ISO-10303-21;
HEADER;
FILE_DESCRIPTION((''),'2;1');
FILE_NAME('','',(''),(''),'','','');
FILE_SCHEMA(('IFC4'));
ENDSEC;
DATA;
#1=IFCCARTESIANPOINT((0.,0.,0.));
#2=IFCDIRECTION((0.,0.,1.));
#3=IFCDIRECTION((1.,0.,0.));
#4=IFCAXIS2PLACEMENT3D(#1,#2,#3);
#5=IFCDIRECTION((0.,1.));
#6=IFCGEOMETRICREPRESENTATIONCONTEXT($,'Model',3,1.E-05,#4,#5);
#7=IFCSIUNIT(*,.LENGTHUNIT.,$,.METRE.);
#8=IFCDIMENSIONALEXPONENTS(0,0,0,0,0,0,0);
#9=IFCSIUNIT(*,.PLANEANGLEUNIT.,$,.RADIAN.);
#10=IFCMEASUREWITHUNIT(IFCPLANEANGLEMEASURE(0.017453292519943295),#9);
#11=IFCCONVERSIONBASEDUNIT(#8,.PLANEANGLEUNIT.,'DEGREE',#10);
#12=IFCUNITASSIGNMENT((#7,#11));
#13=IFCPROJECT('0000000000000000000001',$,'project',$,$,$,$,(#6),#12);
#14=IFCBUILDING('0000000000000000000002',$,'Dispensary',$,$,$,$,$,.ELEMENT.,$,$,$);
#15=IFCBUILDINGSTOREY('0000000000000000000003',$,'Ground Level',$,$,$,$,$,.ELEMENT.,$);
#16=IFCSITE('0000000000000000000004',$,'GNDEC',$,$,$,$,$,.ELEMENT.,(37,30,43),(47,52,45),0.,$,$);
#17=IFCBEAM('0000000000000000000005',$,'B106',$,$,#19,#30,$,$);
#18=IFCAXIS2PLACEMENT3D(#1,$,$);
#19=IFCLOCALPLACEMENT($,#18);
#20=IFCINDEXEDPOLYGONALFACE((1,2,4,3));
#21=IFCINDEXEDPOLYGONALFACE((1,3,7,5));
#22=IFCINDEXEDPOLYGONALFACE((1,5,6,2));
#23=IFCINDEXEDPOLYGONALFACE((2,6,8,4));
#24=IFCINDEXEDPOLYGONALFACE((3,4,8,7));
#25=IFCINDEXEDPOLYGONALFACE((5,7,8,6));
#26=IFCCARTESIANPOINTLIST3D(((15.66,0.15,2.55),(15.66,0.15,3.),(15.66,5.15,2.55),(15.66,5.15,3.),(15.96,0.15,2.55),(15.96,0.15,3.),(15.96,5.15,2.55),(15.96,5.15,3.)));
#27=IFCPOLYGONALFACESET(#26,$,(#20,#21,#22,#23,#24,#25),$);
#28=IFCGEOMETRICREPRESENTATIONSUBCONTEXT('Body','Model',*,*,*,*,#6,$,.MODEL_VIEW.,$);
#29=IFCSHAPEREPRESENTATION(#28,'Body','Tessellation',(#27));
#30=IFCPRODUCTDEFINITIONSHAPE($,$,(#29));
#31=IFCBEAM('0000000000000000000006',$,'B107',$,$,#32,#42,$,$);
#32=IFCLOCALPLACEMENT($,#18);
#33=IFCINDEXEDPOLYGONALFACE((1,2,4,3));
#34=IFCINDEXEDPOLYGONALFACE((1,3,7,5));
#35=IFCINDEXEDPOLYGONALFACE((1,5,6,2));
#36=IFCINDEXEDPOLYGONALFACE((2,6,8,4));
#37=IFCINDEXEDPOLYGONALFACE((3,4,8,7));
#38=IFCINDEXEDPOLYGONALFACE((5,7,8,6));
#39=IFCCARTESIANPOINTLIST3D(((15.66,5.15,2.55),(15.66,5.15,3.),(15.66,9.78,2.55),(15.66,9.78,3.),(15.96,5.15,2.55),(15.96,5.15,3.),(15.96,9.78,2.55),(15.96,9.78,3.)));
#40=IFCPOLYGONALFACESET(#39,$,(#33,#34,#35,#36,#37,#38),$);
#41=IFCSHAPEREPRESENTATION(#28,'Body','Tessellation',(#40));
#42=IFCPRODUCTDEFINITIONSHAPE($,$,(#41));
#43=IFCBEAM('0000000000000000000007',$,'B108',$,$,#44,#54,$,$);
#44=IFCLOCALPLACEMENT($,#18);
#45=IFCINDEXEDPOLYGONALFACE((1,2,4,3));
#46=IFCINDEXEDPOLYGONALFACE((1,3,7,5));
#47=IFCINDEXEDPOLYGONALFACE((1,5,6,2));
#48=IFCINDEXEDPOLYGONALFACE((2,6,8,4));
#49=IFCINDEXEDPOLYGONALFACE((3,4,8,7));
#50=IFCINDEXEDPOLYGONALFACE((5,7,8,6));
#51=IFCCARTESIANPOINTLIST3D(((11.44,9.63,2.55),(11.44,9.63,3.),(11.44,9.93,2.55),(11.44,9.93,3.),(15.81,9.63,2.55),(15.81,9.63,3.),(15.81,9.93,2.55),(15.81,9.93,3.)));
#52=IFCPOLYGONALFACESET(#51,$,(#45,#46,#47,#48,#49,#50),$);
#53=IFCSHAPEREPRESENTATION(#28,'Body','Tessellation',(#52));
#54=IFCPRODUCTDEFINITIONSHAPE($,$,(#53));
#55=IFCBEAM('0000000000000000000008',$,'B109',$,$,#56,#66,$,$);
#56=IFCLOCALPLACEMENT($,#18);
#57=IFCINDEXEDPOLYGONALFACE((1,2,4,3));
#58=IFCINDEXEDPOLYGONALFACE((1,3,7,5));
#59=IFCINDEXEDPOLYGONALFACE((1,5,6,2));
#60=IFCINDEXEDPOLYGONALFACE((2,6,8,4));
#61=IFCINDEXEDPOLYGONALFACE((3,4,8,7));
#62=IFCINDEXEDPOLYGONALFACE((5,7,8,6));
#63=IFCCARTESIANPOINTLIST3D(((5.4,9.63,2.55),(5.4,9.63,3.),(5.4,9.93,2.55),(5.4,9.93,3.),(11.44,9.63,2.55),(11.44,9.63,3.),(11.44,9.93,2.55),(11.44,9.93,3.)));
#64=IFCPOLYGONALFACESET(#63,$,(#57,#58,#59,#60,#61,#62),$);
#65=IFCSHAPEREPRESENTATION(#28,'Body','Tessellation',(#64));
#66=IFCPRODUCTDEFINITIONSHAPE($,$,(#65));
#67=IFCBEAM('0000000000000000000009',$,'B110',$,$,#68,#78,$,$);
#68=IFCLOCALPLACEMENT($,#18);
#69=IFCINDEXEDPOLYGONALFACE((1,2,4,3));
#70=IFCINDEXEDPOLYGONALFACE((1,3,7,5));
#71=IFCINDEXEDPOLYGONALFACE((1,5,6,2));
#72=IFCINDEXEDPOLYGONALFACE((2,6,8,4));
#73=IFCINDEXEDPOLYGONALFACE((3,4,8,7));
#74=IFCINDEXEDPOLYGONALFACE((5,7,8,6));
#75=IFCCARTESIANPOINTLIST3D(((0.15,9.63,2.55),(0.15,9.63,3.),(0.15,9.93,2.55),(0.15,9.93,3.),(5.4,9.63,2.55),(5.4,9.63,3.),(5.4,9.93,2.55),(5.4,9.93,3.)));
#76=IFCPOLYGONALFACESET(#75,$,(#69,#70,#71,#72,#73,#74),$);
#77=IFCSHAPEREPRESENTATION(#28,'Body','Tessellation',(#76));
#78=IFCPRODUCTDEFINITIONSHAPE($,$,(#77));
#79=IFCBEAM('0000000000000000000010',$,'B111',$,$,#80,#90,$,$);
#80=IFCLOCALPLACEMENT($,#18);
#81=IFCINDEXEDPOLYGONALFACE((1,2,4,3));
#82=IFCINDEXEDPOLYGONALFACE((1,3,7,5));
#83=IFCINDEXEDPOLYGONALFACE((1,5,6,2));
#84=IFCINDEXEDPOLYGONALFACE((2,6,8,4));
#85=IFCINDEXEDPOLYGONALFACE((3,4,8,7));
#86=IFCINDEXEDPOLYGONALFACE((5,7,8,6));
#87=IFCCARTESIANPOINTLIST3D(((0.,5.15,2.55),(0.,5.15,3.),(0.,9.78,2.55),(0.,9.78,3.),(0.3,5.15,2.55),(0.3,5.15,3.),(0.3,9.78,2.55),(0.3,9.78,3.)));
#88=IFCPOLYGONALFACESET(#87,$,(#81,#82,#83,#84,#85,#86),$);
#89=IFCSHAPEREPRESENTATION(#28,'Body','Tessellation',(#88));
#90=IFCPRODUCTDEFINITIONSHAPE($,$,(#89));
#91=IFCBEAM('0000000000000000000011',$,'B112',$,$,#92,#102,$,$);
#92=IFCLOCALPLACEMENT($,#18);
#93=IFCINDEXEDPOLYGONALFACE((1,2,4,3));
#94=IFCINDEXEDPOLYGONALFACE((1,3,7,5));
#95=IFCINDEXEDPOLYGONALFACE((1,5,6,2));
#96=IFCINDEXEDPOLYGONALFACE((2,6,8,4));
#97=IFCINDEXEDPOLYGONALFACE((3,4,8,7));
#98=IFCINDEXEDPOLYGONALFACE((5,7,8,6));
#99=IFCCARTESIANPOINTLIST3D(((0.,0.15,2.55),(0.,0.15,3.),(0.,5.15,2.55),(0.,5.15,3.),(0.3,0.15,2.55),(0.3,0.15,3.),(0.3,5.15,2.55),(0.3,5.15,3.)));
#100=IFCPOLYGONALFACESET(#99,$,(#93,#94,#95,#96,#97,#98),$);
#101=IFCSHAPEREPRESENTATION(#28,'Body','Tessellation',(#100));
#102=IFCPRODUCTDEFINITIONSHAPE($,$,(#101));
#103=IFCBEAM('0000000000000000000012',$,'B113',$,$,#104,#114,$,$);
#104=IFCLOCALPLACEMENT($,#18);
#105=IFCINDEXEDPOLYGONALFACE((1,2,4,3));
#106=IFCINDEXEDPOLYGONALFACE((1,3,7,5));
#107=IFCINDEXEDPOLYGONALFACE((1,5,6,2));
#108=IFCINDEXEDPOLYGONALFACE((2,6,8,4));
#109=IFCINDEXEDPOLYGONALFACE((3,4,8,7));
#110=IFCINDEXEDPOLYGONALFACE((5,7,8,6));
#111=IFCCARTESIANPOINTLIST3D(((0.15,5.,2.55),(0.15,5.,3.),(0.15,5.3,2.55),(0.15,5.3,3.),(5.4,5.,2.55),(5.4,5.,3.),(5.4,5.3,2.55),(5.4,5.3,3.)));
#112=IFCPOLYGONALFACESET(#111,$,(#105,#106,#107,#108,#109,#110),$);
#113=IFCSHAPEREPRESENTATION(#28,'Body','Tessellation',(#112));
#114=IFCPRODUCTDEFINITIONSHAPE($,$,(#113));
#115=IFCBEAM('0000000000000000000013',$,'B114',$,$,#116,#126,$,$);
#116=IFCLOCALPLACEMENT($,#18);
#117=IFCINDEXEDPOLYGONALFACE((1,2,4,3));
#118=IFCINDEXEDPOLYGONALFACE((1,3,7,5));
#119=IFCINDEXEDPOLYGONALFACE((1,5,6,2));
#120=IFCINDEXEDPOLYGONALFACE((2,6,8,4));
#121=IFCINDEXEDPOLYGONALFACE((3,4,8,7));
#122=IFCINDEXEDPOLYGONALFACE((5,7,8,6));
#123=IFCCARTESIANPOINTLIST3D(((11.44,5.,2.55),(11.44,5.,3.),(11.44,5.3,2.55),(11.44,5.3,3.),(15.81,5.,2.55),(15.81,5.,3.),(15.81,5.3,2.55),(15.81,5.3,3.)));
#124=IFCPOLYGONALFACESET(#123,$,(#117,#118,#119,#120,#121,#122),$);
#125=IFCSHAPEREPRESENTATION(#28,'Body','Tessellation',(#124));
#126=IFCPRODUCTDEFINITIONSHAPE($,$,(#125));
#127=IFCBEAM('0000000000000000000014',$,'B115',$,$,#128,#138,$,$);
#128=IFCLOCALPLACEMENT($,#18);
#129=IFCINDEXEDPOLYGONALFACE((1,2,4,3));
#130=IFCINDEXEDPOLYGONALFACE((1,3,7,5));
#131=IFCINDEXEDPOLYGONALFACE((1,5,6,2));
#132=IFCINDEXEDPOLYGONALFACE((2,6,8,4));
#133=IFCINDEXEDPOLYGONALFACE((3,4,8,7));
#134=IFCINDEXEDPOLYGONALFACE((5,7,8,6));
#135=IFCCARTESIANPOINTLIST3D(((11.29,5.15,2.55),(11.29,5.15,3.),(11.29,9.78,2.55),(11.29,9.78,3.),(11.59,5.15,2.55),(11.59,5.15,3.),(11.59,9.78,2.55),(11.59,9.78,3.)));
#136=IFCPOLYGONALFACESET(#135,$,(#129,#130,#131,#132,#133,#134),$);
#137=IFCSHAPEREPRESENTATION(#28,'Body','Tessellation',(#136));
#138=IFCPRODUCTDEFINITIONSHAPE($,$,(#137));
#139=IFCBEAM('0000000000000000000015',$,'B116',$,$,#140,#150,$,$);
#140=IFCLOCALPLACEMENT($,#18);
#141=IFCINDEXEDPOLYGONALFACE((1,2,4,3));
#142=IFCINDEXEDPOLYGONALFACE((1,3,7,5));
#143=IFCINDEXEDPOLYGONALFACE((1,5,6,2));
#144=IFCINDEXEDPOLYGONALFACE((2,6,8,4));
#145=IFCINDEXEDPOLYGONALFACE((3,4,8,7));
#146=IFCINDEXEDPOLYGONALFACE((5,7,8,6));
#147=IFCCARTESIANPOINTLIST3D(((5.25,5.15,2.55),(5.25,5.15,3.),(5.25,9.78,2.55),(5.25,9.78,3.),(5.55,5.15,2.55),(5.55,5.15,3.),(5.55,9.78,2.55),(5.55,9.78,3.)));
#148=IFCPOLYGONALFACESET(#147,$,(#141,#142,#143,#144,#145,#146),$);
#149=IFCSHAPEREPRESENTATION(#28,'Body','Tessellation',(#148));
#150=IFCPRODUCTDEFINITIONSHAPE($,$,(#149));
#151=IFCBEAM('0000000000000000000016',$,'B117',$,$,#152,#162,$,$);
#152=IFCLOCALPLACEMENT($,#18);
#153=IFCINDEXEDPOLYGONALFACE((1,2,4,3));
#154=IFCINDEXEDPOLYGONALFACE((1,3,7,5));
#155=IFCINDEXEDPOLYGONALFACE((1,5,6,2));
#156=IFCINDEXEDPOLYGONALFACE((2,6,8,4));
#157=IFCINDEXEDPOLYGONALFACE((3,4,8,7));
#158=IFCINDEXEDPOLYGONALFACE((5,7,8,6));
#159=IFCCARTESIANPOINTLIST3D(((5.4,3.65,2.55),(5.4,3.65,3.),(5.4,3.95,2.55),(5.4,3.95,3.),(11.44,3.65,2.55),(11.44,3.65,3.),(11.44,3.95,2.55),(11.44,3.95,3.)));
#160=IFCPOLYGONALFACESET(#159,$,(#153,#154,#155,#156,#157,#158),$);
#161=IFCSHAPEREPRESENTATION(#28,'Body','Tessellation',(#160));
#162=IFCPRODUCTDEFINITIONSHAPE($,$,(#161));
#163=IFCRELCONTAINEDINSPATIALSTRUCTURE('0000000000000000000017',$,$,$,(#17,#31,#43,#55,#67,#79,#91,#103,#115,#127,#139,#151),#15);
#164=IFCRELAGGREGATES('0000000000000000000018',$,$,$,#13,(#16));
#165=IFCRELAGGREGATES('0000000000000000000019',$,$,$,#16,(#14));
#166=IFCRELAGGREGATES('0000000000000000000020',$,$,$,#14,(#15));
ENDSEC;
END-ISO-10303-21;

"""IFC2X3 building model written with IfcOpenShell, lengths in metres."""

from ifc_helpers import new_model, entity, si_unit, converted_unit, direction, frame, frame_2d, origin_with_axes, place, context, subcontext, project, spatial, rectangle, extrude, element, save


model = new_model("IFC2X3")

# Units and contexts
model_context = context("Model", 3, precision=1e-05, world=origin_with_axes(), true_north=direction((0.0, 1.0)))
body_context = subcontext(model_context, "Body", "Model", "MODEL_VIEW")
ifc_project = project(units=[si_unit("LENGTHUNIT", "METRE"), converted_unit("PLANEANGLEUNIT", "DEGREE", entity("IfcPlaneAngleMeasure", 0.017453292519943295), si_unit("PLANEANGLEUNIT", "RADIAN"), dimensions=[0, 0, 0, 0, 0, 0, 0])], contexts=[model_context])

# Site, building, storey
site = spatial("IfcSite", under=ifc_project, Name="GNDEC", CompositionType="ELEMENT", RefLatitude=(37, 30, 43), RefLongitude=(47, 52, 45), RefElevation=0.0)
building = spatial("IfcBuilding", under=site, Name="Dispensary", CompositionType="ELEMENT")
storey = spatial("IfcBuildingStorey", under=building, Name="Ground Level", CompositionType="ELEMENT")

# Shared definitions
placement = place(None, origin_with_axes())

# Beams
element("IfcBeam", 1, at=placement, inside=storey, Name="B106", context=body_context, shape_type="SweptSolid", body=[
    extrude(rectangle(XDim=0.3, YDim=0.45, at=frame_2d((0.0, 0.0), x_axis=(0.0, 1.0))), frame((15.81, 0.15, 2.775), z_axis=(0.0, 1.0, 0.0), x_axis=(0.0, 0.0, -1.0)), (0.0, 0.0, 1.0), 5.0),
])
element("IfcBeam", 2, at=placement, inside=storey, Name="B107", context=body_context, shape_type="SweptSolid", body=[
    extrude(rectangle(XDim=0.3, YDim=0.45, at=frame_2d((0.0, 0.0), x_axis=(0.0, 1.0))), frame((15.81, 5.15, 2.775), z_axis=(0.0, 1.0, 0.0), x_axis=(0.0, 0.0, -1.0)), (0.0, 0.0, 1.0), 4.63),
])
element("IfcBeam", 3, at=placement, inside=storey, Name="B108", context=body_context, shape_type="SweptSolid", body=[
    extrude(rectangle(XDim=0.3, YDim=0.45, at=frame_2d((0.0, 0.0), x_axis=(0.0, 1.0))), frame((15.81, 9.78, 2.775), z_axis=(-1.0, 0.0, 0.0), x_axis=(0.0, 0.0, -1.0)), (0.0, 0.0, 1.0), 4.37),
])
element("IfcBeam", 4, at=placement, inside=storey, Name="B109", context=body_context, shape_type="SweptSolid", body=[
    extrude(rectangle(XDim=0.3, YDim=0.45, at=frame_2d((0.0, 0.0), x_axis=(0.0, 1.0))), frame((11.44, 9.78, 2.775), z_axis=(-1.0, 0.0, 0.0), x_axis=(0.0, 0.0, -1.0)), (0.0, 0.0, 1.0), 6.04),
])
element("IfcBeam", 5, at=placement, inside=storey, Name="B110", context=body_context, shape_type="SweptSolid", body=[
    extrude(rectangle(XDim=0.3, YDim=0.45, at=frame_2d((0.0, 0.0), x_axis=(0.0, 1.0))), frame((5.4, 9.78, 2.775), z_axis=(-1.0, 0.0, 0.0), x_axis=(0.0, 0.0, -1.0)), (0.0, 0.0, 1.0), 5.25),
])
element("IfcBeam", 6, at=placement, inside=storey, Name="B111", context=body_context, shape_type="SweptSolid", body=[
    extrude(rectangle(XDim=0.3, YDim=0.45, at=frame_2d((0.0, 0.0), x_axis=(0.0, 1.0))), frame((0.15, 9.78, 2.775), z_axis=(0.0, -1.0, 0.0), x_axis=(0.0, 0.0, -1.0)), (0.0, 0.0, 1.0), 4.63),
])
element("IfcBeam", 7, at=placement, inside=storey, Name="B112", context=body_context, shape_type="SweptSolid", body=[
    extrude(rectangle(XDim=0.3, YDim=0.45, at=frame_2d((0.0, 0.0), x_axis=(0.0, 1.0))), frame((0.15, 5.15, 2.775), z_axis=(0.0, -1.0, 0.0), x_axis=(0.0, 0.0, -1.0)), (0.0, 0.0, 1.0), 5.0),
])
element("IfcBeam", 8, at=placement, inside=storey, Name="B113", context=body_context, shape_type="SweptSolid", body=[
    extrude(rectangle(XDim=0.3, YDim=0.45, at=frame_2d((0.0, 0.0), x_axis=(0.0, 1.0))), frame((0.15, 5.15, 2.775), z_axis=(1.0, 0.0, 0.0), x_axis=(0.0, 0.0, -1.0)), (0.0, 0.0, 1.0), 5.25),
])
element("IfcBeam", 9, at=placement, inside=storey, Name="B114", context=body_context, shape_type="SweptSolid", body=[
    extrude(rectangle(XDim=0.3, YDim=0.45, at=frame_2d((0.0, 0.0), x_axis=(0.0, 1.0))), frame((15.81, 5.15, 2.775), z_axis=(-1.0, 0.0, 0.0), x_axis=(0.0, 0.0, -1.0)), (0.0, 0.0, 1.0), 4.37),
])
element("IfcBeam", 10, at=placement, inside=storey, Name="B115", context=body_context, shape_type="SweptSolid", body=[
    extrude(rectangle(XDim=0.3, YDim=0.45, at=frame_2d((0.0, 0.0), x_axis=(0.0, 1.0))), frame((11.44, 5.15, 2.775), z_axis=(0.0, 1.0, 0.0), x_axis=(0.0, 0.0, -1.0)), (0.0, 0.0, 1.0), 4.63),
])
element("IfcBeam", 11, at=placement, inside=storey, Name="B116", context=body_context, shape_type="SweptSolid", body=[
    extrude(rectangle(XDim=0.3, YDim=0.45, at=frame_2d((0.0, 0.0), x_axis=(0.0, 1.0))), frame((5.4, 5.15, 2.775), z_axis=(0.0, 1.0, 0.0), x_axis=(0.0, 0.0, -1.0)), (0.0, 0.0, 1.0), 4.63),
])
element("IfcBeam", 12, at=placement, inside=storey, Name="B117", context=body_context, shape_type="SweptSolid", body=[
    extrude(rectangle(XDim=0.3, YDim=0.45, at=frame_2d((0.0, 0.0), x_axis=(0.0, 1.0))), frame((5.4, 3.8, 2.775), z_axis=(1.0, 0.0, 0.0), x_axis=(0.0, 0.0, -1.0)), (0.0, 0.0, 1.0), 6.04),
])

save(model, "model.ifc")
